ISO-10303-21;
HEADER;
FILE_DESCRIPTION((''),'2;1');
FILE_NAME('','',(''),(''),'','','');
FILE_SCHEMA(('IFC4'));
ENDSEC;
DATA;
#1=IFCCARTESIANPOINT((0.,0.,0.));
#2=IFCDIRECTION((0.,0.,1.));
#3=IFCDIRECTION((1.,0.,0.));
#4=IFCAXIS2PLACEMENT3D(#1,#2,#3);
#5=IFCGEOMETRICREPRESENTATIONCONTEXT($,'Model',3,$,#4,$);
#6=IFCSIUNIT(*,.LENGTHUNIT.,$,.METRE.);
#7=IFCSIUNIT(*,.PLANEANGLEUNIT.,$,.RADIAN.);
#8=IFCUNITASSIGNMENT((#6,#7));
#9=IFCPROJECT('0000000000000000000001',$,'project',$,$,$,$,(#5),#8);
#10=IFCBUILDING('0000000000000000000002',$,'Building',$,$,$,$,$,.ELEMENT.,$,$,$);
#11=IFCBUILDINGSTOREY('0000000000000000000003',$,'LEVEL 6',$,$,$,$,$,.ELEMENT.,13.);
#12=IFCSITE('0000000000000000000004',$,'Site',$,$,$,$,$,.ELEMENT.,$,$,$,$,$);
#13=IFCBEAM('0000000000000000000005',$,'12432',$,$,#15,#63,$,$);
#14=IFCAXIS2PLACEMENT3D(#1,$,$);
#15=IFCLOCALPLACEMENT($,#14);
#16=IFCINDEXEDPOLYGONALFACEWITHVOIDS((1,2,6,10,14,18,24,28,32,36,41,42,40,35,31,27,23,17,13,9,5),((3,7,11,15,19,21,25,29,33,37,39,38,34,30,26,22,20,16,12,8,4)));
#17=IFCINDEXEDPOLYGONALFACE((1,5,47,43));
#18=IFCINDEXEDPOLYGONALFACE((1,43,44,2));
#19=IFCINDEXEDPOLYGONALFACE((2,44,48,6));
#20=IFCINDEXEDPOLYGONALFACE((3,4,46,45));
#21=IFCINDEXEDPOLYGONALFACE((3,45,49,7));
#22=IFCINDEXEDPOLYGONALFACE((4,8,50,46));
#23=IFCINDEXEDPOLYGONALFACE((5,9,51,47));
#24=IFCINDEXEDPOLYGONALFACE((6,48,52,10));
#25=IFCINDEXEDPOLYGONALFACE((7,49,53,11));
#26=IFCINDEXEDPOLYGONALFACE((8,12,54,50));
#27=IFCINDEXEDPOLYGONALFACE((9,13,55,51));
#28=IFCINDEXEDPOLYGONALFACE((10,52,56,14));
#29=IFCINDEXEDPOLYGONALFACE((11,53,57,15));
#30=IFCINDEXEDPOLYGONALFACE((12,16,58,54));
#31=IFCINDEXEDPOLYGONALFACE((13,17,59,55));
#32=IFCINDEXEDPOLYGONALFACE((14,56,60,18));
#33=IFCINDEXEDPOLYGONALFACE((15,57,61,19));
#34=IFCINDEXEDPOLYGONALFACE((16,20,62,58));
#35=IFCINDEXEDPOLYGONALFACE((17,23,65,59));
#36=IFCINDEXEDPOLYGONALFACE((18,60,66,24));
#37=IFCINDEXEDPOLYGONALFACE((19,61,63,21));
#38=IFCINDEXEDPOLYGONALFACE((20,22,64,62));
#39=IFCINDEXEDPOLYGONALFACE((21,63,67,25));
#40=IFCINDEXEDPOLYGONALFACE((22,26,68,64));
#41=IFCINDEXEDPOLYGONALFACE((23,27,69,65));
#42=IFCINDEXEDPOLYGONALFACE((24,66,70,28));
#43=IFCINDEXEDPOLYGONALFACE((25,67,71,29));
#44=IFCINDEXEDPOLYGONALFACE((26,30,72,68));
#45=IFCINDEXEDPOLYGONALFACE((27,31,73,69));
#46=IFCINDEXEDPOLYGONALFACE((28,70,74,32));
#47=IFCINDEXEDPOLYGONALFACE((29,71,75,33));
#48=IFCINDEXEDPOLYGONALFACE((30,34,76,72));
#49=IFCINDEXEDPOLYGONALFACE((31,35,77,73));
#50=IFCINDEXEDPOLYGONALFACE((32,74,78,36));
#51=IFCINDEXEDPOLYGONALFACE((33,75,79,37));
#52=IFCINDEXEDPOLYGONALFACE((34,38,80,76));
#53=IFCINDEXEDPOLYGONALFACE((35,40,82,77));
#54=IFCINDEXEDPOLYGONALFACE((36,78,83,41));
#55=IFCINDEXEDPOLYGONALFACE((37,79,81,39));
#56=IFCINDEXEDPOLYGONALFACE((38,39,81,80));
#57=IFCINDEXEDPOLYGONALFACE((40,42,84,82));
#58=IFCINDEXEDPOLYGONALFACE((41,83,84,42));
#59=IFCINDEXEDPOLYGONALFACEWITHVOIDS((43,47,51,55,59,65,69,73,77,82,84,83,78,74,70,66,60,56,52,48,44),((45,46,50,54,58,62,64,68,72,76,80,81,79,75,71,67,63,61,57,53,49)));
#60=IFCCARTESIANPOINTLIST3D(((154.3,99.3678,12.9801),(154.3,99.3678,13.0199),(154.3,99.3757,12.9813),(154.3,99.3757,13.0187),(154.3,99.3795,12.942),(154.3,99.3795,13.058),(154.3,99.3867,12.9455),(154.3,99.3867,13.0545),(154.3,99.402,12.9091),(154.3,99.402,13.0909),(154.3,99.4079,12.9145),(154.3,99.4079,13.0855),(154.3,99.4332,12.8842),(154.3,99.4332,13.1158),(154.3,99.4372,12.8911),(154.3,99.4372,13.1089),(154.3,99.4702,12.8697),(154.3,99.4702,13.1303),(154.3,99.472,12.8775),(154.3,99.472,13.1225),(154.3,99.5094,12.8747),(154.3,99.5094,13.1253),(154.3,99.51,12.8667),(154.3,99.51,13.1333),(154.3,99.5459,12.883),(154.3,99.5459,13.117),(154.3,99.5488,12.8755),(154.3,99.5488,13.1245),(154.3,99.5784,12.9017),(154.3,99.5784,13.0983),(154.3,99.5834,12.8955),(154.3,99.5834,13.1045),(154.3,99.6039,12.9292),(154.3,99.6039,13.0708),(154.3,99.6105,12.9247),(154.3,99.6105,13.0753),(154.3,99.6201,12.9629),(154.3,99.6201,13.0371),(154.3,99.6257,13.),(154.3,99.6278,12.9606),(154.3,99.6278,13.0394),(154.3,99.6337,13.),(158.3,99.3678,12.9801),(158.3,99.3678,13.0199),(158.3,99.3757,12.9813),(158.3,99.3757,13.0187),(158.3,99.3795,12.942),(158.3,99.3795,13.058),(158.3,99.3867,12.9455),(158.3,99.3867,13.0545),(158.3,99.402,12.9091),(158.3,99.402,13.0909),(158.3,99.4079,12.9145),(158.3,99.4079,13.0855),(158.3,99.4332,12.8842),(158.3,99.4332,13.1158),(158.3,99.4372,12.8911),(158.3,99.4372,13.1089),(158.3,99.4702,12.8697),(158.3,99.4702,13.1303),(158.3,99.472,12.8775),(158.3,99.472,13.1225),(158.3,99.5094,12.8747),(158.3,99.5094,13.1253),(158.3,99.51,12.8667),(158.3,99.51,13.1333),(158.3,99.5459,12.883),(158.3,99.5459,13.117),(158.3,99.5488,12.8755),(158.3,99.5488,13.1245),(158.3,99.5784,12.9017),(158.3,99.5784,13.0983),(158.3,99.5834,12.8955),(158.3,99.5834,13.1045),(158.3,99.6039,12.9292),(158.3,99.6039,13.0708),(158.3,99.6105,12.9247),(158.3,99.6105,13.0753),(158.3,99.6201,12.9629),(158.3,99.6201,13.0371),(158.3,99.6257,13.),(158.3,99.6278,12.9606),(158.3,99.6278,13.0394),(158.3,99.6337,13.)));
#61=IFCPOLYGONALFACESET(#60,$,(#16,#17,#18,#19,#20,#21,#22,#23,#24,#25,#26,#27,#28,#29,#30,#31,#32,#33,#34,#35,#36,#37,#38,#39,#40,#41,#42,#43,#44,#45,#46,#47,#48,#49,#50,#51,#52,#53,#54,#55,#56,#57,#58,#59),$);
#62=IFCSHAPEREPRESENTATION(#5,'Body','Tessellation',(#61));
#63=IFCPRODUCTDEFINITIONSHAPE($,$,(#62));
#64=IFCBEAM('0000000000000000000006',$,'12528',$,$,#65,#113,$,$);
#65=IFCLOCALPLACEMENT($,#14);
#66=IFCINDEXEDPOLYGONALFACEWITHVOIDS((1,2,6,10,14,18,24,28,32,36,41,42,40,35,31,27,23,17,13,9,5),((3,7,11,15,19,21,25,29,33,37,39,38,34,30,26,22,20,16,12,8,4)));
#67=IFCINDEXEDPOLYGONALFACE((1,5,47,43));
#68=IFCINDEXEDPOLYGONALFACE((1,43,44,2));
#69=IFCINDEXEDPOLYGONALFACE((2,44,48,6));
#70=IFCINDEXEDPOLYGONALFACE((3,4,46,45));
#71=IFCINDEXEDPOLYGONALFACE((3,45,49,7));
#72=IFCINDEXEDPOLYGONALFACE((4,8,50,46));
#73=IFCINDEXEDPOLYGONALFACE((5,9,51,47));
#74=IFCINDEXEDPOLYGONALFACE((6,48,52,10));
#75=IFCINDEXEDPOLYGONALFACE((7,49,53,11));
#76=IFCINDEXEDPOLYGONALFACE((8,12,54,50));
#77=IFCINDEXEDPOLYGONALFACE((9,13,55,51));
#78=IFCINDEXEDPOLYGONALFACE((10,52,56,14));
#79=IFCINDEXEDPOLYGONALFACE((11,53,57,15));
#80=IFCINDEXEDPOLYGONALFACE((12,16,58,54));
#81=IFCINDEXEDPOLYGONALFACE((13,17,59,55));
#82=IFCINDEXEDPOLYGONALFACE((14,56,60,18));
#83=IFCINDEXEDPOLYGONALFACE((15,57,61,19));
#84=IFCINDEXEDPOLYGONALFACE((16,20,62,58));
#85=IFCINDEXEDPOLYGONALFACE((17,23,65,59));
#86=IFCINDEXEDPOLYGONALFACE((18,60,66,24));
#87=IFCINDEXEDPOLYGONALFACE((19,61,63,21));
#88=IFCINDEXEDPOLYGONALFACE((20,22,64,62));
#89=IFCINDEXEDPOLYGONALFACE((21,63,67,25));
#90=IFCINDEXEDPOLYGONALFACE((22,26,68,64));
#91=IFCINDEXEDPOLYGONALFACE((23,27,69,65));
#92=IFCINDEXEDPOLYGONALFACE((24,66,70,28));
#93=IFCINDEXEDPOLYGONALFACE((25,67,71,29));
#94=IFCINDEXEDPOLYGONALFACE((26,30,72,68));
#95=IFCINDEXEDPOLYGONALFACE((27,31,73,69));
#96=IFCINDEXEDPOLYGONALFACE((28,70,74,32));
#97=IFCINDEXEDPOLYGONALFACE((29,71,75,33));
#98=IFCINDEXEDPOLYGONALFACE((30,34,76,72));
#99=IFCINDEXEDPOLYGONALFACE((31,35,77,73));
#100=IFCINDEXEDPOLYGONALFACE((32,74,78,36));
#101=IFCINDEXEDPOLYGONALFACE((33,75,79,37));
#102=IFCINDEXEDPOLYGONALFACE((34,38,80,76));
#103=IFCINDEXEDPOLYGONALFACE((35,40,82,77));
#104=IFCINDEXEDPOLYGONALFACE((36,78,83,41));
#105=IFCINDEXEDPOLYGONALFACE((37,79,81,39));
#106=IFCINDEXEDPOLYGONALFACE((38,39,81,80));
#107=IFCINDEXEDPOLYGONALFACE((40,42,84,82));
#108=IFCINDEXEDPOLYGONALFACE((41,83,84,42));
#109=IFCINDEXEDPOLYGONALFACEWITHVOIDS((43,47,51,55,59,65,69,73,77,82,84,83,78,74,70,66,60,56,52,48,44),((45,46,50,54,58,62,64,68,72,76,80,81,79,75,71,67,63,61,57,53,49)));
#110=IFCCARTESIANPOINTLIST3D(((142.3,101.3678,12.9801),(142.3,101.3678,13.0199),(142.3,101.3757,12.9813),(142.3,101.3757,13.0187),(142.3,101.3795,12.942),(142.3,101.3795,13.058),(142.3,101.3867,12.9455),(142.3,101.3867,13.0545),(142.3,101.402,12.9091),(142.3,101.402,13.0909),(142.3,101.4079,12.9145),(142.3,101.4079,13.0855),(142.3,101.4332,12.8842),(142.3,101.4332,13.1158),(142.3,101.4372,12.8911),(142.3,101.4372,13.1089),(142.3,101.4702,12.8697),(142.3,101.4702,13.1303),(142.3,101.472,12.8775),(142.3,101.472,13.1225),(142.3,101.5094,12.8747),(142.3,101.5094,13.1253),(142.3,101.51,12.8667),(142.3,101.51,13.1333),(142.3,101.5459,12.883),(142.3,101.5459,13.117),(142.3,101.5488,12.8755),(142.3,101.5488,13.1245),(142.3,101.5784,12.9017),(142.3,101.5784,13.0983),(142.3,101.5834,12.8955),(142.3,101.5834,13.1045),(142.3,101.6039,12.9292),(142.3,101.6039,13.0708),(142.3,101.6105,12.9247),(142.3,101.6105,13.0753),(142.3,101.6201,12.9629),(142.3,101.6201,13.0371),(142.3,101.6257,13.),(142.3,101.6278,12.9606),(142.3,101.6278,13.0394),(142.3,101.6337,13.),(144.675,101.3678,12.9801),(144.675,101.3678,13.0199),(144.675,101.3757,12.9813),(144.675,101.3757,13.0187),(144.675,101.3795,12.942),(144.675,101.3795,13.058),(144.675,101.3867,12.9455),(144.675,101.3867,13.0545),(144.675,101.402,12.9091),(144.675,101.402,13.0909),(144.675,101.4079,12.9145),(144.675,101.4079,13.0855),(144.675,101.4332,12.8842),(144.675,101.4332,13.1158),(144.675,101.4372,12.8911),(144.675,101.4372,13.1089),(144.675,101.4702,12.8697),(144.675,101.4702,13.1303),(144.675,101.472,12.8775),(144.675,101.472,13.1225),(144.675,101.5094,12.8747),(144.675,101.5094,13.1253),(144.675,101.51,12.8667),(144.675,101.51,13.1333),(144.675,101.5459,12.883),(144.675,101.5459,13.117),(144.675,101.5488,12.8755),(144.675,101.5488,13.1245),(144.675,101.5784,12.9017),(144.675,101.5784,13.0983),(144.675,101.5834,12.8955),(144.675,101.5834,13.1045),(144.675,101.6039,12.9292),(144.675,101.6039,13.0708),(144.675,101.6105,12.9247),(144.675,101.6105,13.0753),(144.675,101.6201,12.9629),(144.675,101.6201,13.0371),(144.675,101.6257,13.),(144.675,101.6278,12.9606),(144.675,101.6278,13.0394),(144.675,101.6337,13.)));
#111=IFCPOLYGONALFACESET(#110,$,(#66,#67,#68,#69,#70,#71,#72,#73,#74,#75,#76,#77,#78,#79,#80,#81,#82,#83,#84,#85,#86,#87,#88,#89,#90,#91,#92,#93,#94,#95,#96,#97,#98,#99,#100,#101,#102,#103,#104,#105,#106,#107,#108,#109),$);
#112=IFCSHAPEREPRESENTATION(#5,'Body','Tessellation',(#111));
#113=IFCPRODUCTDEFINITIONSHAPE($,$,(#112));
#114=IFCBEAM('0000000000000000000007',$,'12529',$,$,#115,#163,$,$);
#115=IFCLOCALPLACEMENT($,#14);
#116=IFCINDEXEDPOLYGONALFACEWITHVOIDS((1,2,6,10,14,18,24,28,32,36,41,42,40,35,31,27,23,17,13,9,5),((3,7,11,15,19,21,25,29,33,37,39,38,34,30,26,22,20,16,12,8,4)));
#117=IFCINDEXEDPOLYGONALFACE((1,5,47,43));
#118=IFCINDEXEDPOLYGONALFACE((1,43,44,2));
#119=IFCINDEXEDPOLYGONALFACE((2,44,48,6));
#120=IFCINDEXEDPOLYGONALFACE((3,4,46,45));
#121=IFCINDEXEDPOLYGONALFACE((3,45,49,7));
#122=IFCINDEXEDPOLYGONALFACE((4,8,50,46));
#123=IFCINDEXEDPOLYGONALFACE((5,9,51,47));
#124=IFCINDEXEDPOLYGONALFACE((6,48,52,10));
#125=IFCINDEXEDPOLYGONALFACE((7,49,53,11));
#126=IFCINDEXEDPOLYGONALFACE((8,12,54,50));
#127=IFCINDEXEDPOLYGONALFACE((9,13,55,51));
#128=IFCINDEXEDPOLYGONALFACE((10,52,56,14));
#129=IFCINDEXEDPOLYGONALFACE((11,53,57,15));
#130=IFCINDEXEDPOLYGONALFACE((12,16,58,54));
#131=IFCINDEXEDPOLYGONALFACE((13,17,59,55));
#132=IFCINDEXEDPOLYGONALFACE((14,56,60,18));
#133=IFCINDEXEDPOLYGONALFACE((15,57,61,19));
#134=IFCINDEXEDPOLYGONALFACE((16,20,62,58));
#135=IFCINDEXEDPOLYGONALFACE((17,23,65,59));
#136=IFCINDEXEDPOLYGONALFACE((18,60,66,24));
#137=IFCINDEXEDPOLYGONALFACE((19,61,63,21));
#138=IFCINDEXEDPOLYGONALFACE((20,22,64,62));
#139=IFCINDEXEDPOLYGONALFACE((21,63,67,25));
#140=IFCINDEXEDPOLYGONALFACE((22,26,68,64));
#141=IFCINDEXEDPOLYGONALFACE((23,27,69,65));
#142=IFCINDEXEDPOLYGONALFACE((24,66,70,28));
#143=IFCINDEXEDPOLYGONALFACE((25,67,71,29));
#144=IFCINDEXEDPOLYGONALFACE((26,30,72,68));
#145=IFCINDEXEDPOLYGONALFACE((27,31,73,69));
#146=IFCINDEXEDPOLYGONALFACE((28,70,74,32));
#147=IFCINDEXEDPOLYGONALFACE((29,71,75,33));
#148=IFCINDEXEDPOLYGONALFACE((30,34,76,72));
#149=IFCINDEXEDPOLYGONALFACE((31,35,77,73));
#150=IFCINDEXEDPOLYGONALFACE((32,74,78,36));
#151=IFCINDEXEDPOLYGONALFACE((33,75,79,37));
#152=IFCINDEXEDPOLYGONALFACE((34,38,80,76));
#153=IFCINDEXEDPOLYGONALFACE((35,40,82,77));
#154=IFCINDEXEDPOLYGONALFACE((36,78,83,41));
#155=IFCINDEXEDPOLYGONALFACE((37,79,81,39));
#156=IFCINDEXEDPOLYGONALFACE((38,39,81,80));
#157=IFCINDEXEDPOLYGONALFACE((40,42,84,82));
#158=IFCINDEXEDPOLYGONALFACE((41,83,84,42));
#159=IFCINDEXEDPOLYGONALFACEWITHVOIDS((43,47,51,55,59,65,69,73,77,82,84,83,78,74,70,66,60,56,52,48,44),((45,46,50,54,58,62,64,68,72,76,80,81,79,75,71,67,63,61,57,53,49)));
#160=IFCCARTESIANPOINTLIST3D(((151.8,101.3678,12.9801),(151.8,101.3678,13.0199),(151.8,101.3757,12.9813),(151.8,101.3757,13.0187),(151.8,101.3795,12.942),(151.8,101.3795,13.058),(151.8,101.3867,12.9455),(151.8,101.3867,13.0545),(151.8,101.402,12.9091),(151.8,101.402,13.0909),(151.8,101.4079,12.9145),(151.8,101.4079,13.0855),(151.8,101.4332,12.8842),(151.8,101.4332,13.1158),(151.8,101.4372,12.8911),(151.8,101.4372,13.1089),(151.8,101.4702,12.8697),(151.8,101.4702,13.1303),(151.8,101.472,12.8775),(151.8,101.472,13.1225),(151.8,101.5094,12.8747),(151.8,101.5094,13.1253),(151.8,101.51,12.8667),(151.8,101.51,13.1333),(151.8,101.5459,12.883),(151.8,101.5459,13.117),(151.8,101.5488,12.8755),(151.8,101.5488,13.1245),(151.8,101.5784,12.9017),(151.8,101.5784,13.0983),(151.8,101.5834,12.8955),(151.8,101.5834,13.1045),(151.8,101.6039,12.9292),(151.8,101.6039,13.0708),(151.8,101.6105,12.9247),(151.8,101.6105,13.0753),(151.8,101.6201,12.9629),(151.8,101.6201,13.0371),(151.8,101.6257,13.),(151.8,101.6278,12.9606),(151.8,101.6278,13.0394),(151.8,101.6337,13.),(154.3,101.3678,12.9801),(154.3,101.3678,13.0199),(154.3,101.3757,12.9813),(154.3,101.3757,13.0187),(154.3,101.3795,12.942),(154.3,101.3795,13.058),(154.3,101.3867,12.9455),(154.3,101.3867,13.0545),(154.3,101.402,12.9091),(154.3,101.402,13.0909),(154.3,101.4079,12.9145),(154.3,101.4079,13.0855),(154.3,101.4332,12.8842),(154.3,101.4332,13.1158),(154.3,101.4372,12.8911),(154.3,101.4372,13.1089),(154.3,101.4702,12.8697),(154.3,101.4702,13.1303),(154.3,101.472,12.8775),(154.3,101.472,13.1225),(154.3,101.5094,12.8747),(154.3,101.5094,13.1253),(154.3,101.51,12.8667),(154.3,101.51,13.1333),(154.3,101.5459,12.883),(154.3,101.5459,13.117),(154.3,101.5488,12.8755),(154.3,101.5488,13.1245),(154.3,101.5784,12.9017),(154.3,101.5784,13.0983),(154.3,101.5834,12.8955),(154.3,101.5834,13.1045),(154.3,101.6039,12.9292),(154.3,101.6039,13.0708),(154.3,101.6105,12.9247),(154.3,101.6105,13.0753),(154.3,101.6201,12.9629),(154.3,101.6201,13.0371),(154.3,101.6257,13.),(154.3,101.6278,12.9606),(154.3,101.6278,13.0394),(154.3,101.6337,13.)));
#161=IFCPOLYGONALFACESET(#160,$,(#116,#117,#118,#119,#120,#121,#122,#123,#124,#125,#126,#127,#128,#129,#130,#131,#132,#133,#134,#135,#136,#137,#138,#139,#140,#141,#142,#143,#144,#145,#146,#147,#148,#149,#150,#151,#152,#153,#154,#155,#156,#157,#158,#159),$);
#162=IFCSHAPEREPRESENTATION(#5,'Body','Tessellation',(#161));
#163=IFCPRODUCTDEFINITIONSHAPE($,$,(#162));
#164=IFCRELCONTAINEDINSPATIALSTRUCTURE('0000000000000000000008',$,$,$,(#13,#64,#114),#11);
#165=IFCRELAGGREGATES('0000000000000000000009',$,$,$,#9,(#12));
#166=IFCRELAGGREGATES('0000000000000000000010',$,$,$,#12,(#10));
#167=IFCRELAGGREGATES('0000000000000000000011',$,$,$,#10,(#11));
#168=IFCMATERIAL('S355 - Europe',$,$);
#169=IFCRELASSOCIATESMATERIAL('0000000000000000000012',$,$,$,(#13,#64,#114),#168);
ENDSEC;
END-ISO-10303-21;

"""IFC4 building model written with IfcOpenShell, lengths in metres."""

from ifc_helpers import new_model, si_unit, frame, origin_with_axes, origin_2d_with_axis, place, context, project, spatial, hollow_circle, extrude, material, material_profile, profile_set, profile_usage, element, save


model = new_model("IFC4")

# Units and contexts
model_context = context("Model", 3, world=origin_with_axes())
ifc_project = project(units=[si_unit("LENGTHUNIT", "METRE"), si_unit("PLANEANGLEUNIT", "RADIAN")], contexts=[model_context])

# Site, building, storey
site = spatial("IfcSite", under=ifc_project, Name="Site", CompositionType="ELEMENT")
building = spatial("IfcBuilding", under=site, Name="Building", CompositionType="ELEMENT")
storey = spatial("IfcBuildingStorey", under=building, Name="LEVEL 6", CompositionType="ELEMENT", Elevation=13.0)

# Shared definitions
ifc_material = material(Name="S355 - Europe")

# Beams
ifc_material_profile_1 = material_profile(ifc_material, hollow_circle(Radius=0.1337, WallThickness=0.008, at=origin_2d_with_axis()))
ifc_profile_set_1 = profile_set([ifc_material_profile_1])
ifc_profile_usage_1 = profile_usage(ifc_profile_set_1, cardinal=10)
beam_1_placement = place(None, frame((154.3, 99.5, 13.0), z_axis=(1.0, 0.0, 0.0), x_axis=(0.0, 1.0, 0.0)))
element("IfcBeam", 1, at=beam_1_placement, inside=storey, material=ifc_profile_usage_1, Name="12432", context=model_context, shape_type="SweptSolid", body=[
    extrude(hollow_circle(Radius=0.1337, WallThickness=0.008, at=origin_2d_with_axis()), origin_with_axes(), (0.0, 0.0, 1.0), 4.0),
])
ifc_material_profile_2 = material_profile(ifc_material, hollow_circle(Radius=0.1337, WallThickness=0.008, at=origin_2d_with_axis()))
ifc_profile_set_2 = profile_set([ifc_material_profile_2])
ifc_profile_usage_2 = profile_usage(ifc_profile_set_2, cardinal=10)
beam_2_placement = place(None, frame((142.3, 101.5, 13.0), z_axis=(1.0, 0.0, 0.0), x_axis=(0.0, 1.0, 0.0)))
element("IfcBeam", 2, at=beam_2_placement, inside=storey, material=ifc_profile_usage_2, Name="12528", context=model_context, shape_type="SweptSolid", body=[
    extrude(hollow_circle(Radius=0.1337, WallThickness=0.008, at=origin_2d_with_axis()), origin_with_axes(), (0.0, 0.0, 1.0), 2.375),
])
ifc_material_profile_3 = material_profile(ifc_material, hollow_circle(Radius=0.1337, WallThickness=0.008, at=origin_2d_with_axis()))
ifc_profile_set_3 = profile_set([ifc_material_profile_3])
ifc_profile_usage_3 = profile_usage(ifc_profile_set_3, cardinal=10)
beam_3_placement = place(None, frame((151.8, 101.5, 13.0), z_axis=(1.0, 0.0, 0.0), x_axis=(0.0, 1.0, 0.0)))
element("IfcBeam", 3, at=beam_3_placement, inside=storey, material=ifc_profile_usage_3, Name="12529", context=model_context, shape_type="SweptSolid", body=[
    extrude(hollow_circle(Radius=0.1337, WallThickness=0.008, at=origin_2d_with_axis()), origin_with_axes(), (0.0, 0.0, 1.0), 2.5),
])

save(model, "model.ifc")
